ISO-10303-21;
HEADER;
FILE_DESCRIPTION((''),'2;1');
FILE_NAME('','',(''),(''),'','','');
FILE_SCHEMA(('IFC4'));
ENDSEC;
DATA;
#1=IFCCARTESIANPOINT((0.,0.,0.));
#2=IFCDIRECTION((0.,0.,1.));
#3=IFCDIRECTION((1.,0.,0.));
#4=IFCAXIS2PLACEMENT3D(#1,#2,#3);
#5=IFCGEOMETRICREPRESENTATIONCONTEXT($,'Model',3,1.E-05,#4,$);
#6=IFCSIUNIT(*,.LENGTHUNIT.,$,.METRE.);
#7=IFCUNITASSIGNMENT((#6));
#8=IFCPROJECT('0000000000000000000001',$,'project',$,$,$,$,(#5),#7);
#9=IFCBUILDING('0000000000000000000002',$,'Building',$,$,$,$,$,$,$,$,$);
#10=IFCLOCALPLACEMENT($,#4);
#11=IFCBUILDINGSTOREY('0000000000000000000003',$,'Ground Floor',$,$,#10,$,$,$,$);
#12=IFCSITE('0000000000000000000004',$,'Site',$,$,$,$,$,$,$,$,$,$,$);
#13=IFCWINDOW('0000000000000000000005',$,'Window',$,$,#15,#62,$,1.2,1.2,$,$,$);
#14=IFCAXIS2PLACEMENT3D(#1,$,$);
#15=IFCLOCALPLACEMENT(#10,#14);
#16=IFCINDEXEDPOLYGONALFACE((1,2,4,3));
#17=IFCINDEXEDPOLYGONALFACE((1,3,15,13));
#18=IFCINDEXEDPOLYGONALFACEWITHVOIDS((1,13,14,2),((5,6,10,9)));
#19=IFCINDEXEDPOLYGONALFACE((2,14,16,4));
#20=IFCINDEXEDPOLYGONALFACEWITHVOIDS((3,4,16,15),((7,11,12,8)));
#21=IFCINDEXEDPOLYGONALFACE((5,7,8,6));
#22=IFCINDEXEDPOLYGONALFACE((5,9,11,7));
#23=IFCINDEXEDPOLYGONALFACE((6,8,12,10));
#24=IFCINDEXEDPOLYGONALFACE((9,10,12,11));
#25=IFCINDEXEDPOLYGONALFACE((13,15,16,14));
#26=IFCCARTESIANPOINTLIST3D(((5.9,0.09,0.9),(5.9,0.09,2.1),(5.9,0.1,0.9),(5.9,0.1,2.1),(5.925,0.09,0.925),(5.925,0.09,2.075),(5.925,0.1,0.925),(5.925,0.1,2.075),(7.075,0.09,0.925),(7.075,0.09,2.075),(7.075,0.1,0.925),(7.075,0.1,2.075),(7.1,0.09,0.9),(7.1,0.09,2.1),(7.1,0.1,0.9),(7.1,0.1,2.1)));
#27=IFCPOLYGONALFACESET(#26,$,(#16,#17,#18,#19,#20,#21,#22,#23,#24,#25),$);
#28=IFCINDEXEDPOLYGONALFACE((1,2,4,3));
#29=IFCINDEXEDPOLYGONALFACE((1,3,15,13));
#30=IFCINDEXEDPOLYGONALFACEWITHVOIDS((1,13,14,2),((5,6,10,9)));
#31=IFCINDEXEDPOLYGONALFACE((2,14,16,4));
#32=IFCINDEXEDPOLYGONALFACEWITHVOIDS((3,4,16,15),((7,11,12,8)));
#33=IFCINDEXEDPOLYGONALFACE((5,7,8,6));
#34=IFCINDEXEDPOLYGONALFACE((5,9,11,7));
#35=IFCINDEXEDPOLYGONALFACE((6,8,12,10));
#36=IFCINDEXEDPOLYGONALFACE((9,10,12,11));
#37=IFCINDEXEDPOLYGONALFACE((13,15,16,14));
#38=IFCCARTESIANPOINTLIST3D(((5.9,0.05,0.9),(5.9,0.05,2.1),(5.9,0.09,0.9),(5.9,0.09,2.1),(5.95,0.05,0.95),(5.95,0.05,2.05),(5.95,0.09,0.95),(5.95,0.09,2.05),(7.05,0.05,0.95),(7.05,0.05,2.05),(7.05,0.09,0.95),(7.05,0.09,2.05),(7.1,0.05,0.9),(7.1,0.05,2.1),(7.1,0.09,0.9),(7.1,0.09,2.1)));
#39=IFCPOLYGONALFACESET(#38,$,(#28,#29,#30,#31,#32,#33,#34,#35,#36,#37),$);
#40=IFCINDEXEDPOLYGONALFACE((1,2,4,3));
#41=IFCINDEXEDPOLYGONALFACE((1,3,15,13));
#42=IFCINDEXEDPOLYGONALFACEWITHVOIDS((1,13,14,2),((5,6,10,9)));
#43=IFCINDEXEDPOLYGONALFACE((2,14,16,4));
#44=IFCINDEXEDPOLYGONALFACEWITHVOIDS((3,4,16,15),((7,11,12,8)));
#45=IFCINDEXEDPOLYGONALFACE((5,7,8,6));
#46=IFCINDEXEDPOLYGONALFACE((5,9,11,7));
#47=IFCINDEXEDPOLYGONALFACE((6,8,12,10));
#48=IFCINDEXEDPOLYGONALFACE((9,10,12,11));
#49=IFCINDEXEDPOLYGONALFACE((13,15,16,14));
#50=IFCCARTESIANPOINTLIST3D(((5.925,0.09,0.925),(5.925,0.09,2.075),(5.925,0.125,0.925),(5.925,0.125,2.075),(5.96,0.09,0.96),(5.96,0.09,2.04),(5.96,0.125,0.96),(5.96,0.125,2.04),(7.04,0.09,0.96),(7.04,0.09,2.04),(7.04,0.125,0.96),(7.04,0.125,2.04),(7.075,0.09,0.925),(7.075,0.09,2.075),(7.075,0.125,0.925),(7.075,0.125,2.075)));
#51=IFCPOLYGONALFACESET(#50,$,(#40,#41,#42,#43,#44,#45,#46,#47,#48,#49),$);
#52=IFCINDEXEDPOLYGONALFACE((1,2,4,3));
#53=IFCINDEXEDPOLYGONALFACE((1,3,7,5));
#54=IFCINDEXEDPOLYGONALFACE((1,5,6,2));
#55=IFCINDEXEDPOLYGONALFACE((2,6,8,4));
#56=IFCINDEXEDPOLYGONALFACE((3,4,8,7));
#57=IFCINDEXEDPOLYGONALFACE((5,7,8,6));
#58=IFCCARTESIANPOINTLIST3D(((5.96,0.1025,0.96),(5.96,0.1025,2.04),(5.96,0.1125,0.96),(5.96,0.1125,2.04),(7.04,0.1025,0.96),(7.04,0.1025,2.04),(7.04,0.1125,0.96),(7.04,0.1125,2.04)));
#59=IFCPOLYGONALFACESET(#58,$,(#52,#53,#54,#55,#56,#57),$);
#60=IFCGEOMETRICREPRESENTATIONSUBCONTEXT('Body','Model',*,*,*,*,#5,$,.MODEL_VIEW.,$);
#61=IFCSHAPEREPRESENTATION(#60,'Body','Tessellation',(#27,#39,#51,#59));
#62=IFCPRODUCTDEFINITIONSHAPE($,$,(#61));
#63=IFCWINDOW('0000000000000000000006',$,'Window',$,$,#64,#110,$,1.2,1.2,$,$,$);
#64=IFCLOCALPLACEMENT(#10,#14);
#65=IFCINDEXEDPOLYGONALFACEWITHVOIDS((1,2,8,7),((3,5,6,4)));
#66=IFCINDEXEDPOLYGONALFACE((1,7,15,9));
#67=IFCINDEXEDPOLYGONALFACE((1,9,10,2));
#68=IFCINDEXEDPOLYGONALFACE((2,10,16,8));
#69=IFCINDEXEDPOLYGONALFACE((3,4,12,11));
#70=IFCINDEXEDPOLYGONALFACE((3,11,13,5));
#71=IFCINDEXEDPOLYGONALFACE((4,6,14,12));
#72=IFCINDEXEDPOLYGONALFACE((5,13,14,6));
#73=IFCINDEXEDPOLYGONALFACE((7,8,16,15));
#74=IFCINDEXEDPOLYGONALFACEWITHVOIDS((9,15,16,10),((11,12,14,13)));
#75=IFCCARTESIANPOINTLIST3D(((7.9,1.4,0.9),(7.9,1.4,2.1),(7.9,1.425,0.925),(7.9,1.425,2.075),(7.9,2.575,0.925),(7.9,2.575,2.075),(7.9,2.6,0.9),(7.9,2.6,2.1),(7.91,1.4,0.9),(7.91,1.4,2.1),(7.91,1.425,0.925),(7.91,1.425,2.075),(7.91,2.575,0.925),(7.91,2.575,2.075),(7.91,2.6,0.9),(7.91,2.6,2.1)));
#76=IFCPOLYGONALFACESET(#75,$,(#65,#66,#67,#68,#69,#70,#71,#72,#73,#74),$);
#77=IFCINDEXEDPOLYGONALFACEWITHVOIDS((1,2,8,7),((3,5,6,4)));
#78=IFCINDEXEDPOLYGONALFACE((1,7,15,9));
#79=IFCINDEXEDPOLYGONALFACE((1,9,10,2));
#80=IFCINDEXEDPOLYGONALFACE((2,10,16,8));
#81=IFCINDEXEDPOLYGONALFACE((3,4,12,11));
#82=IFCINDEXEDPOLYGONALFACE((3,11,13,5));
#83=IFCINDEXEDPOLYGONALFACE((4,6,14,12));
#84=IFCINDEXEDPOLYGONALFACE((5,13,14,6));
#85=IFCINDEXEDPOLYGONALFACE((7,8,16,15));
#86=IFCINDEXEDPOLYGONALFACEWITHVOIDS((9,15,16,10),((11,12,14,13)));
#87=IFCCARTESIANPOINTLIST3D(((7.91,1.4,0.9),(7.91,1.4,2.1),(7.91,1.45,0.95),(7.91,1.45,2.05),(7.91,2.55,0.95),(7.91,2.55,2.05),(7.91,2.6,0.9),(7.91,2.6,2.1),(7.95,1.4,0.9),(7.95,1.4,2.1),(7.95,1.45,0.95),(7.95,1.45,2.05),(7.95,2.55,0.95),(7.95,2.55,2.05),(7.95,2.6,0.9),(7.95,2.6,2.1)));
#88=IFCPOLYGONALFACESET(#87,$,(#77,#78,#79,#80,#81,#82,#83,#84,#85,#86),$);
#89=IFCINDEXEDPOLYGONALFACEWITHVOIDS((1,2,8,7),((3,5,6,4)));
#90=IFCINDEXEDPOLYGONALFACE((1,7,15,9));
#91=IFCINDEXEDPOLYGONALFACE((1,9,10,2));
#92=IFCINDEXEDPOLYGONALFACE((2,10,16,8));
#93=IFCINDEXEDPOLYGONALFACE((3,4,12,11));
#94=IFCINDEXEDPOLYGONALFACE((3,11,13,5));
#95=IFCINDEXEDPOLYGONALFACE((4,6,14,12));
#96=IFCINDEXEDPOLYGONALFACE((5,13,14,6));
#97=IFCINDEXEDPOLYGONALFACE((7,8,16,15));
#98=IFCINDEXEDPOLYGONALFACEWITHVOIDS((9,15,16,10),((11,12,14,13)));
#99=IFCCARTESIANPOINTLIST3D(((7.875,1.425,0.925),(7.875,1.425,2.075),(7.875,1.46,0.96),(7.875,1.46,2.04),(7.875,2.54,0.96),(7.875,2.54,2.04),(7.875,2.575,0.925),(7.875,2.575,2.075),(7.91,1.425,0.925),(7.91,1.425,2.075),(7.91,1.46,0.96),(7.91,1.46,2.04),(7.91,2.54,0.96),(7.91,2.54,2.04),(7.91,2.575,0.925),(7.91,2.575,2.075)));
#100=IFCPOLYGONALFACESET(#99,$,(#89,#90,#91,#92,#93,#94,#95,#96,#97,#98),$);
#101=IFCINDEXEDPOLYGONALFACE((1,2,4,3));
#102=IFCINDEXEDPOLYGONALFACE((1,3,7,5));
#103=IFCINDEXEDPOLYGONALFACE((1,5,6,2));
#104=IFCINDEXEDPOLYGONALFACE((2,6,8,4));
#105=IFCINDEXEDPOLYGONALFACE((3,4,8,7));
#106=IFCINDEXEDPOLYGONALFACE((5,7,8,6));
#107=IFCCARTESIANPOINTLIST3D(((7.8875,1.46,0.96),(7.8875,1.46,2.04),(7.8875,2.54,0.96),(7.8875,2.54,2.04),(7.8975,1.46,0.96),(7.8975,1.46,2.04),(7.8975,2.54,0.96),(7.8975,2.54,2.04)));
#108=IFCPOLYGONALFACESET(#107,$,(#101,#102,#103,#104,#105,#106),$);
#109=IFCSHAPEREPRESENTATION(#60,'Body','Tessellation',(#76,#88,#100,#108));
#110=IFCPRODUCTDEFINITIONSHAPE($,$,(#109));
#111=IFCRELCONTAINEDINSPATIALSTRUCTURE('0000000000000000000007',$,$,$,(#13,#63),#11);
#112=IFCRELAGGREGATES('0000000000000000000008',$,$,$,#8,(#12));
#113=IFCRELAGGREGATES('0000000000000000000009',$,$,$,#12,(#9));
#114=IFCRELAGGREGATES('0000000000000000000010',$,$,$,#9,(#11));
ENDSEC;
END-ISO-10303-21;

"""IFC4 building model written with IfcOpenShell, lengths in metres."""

from ifc_helpers import new_model, si_unit, frame, origin_with_axes, place, context, subcontext, project, spatial, line, indexed_curve, outline, extrude, element, save


model = new_model("IFC4")

# Units and contexts
model_context = context("Model", 3, precision=1e-05, world=origin_with_axes())
body_context = subcontext(model_context, "Body", "Model", "MODEL_VIEW")
ifc_project = project(units=[si_unit("LENGTHUNIT", "METRE")], contexts=[model_context])

# Site, building, storey
site = spatial("IfcSite", under=ifc_project, Name="Site")
building = spatial("IfcBuilding", under=site, Name="Building")
storey_placement = place(None, origin_with_axes())
storey = spatial("IfcBuildingStorey", under=building, at=storey_placement, Name="Ground Floor")

# Windows
for number, where, z_axis, x_axis, name in (
    (1, (5.9, 0.0, 0.9), (0.0, 0.0, 1.0), (1.0, 0.0, 0.0), "Window"),
    (2, (8.0, 1.4, 0.9), (0.0, 0.0, 1.0), (0.0, 1.0, 0.0), "Window"),
):
    element("IfcWindow", number, at=place(storey_placement, frame(where, z_axis=z_axis, x_axis=x_axis)), inside=storey, Name=name, OverallHeight=1.2, OverallWidth=1.2, context=body_context, shape_type="SweptSolid", body=[
        extrude(outline(indexed_curve([(0.0, 0.0), (1.2, 0.0), (1.2, 1.2), (0.0, 1.2)], segments=[line(1, 2, 3, 4, 1)]), holes=[indexed_curve([(0.025, 0.025), (1.175, 0.025), (1.175, 1.175), (0.025, 1.175)], segments=[line(1, 2, 3, 4, 1)])]), frame((0.0, 0.09, 0.0), z_axis=(0.0, -1.0, 0.0), x_axis=(1.0, 0.0, 0.0)), (0.0, 0.0, -1.0), 0.01),
        extrude(outline(indexed_curve([(0.0, 0.0), (1.2, 0.0), (1.2, 1.2), (0.0, 1.2)], segments=[line(1, 2, 3, 4, 1)]), holes=[indexed_curve([(0.05, 0.05), (1.15, 0.05), (1.15, 1.15), (0.05, 1.15)], segments=[line(1, 2, 3, 4, 1)])]), frame((0.0, 0.05, 0.0), z_axis=(0.0, -1.0, 0.0), x_axis=(1.0, 0.0, 0.0)), (0.0, 0.0, -1.0), 0.04),
        extrude(outline(indexed_curve([(0.0, 0.0), (1.15, 0.0), (1.15, 1.15), (0.0, 1.15)], segments=[line(1, 2, 3, 4, 1)]), holes=[indexed_curve([(0.035, 0.035), (1.115, 0.035), (1.115, 1.115), (0.035, 1.115)], segments=[line(1, 2, 3, 4, 1)])]), frame((0.025, 0.09, 0.025), z_axis=(0.0, -1.0, 0.0), x_axis=(1.0, 0.0, 0.0)), (0.0, 0.0, -1.0), 0.035),
        extrude(outline(indexed_curve([(0.035, 0.035), (1.115, 0.035), (1.115, 1.115), (0.035, 1.115)], segments=[line(1, 2, 3, 4, 1)])), frame((0.025, 0.1025, 0.025), z_axis=(0.0, -1.0, 0.0), x_axis=(1.0, 0.0, 0.0)), (0.0, 0.0, -1.0), 0.01),
    ])

save(model, "model.ifc")
